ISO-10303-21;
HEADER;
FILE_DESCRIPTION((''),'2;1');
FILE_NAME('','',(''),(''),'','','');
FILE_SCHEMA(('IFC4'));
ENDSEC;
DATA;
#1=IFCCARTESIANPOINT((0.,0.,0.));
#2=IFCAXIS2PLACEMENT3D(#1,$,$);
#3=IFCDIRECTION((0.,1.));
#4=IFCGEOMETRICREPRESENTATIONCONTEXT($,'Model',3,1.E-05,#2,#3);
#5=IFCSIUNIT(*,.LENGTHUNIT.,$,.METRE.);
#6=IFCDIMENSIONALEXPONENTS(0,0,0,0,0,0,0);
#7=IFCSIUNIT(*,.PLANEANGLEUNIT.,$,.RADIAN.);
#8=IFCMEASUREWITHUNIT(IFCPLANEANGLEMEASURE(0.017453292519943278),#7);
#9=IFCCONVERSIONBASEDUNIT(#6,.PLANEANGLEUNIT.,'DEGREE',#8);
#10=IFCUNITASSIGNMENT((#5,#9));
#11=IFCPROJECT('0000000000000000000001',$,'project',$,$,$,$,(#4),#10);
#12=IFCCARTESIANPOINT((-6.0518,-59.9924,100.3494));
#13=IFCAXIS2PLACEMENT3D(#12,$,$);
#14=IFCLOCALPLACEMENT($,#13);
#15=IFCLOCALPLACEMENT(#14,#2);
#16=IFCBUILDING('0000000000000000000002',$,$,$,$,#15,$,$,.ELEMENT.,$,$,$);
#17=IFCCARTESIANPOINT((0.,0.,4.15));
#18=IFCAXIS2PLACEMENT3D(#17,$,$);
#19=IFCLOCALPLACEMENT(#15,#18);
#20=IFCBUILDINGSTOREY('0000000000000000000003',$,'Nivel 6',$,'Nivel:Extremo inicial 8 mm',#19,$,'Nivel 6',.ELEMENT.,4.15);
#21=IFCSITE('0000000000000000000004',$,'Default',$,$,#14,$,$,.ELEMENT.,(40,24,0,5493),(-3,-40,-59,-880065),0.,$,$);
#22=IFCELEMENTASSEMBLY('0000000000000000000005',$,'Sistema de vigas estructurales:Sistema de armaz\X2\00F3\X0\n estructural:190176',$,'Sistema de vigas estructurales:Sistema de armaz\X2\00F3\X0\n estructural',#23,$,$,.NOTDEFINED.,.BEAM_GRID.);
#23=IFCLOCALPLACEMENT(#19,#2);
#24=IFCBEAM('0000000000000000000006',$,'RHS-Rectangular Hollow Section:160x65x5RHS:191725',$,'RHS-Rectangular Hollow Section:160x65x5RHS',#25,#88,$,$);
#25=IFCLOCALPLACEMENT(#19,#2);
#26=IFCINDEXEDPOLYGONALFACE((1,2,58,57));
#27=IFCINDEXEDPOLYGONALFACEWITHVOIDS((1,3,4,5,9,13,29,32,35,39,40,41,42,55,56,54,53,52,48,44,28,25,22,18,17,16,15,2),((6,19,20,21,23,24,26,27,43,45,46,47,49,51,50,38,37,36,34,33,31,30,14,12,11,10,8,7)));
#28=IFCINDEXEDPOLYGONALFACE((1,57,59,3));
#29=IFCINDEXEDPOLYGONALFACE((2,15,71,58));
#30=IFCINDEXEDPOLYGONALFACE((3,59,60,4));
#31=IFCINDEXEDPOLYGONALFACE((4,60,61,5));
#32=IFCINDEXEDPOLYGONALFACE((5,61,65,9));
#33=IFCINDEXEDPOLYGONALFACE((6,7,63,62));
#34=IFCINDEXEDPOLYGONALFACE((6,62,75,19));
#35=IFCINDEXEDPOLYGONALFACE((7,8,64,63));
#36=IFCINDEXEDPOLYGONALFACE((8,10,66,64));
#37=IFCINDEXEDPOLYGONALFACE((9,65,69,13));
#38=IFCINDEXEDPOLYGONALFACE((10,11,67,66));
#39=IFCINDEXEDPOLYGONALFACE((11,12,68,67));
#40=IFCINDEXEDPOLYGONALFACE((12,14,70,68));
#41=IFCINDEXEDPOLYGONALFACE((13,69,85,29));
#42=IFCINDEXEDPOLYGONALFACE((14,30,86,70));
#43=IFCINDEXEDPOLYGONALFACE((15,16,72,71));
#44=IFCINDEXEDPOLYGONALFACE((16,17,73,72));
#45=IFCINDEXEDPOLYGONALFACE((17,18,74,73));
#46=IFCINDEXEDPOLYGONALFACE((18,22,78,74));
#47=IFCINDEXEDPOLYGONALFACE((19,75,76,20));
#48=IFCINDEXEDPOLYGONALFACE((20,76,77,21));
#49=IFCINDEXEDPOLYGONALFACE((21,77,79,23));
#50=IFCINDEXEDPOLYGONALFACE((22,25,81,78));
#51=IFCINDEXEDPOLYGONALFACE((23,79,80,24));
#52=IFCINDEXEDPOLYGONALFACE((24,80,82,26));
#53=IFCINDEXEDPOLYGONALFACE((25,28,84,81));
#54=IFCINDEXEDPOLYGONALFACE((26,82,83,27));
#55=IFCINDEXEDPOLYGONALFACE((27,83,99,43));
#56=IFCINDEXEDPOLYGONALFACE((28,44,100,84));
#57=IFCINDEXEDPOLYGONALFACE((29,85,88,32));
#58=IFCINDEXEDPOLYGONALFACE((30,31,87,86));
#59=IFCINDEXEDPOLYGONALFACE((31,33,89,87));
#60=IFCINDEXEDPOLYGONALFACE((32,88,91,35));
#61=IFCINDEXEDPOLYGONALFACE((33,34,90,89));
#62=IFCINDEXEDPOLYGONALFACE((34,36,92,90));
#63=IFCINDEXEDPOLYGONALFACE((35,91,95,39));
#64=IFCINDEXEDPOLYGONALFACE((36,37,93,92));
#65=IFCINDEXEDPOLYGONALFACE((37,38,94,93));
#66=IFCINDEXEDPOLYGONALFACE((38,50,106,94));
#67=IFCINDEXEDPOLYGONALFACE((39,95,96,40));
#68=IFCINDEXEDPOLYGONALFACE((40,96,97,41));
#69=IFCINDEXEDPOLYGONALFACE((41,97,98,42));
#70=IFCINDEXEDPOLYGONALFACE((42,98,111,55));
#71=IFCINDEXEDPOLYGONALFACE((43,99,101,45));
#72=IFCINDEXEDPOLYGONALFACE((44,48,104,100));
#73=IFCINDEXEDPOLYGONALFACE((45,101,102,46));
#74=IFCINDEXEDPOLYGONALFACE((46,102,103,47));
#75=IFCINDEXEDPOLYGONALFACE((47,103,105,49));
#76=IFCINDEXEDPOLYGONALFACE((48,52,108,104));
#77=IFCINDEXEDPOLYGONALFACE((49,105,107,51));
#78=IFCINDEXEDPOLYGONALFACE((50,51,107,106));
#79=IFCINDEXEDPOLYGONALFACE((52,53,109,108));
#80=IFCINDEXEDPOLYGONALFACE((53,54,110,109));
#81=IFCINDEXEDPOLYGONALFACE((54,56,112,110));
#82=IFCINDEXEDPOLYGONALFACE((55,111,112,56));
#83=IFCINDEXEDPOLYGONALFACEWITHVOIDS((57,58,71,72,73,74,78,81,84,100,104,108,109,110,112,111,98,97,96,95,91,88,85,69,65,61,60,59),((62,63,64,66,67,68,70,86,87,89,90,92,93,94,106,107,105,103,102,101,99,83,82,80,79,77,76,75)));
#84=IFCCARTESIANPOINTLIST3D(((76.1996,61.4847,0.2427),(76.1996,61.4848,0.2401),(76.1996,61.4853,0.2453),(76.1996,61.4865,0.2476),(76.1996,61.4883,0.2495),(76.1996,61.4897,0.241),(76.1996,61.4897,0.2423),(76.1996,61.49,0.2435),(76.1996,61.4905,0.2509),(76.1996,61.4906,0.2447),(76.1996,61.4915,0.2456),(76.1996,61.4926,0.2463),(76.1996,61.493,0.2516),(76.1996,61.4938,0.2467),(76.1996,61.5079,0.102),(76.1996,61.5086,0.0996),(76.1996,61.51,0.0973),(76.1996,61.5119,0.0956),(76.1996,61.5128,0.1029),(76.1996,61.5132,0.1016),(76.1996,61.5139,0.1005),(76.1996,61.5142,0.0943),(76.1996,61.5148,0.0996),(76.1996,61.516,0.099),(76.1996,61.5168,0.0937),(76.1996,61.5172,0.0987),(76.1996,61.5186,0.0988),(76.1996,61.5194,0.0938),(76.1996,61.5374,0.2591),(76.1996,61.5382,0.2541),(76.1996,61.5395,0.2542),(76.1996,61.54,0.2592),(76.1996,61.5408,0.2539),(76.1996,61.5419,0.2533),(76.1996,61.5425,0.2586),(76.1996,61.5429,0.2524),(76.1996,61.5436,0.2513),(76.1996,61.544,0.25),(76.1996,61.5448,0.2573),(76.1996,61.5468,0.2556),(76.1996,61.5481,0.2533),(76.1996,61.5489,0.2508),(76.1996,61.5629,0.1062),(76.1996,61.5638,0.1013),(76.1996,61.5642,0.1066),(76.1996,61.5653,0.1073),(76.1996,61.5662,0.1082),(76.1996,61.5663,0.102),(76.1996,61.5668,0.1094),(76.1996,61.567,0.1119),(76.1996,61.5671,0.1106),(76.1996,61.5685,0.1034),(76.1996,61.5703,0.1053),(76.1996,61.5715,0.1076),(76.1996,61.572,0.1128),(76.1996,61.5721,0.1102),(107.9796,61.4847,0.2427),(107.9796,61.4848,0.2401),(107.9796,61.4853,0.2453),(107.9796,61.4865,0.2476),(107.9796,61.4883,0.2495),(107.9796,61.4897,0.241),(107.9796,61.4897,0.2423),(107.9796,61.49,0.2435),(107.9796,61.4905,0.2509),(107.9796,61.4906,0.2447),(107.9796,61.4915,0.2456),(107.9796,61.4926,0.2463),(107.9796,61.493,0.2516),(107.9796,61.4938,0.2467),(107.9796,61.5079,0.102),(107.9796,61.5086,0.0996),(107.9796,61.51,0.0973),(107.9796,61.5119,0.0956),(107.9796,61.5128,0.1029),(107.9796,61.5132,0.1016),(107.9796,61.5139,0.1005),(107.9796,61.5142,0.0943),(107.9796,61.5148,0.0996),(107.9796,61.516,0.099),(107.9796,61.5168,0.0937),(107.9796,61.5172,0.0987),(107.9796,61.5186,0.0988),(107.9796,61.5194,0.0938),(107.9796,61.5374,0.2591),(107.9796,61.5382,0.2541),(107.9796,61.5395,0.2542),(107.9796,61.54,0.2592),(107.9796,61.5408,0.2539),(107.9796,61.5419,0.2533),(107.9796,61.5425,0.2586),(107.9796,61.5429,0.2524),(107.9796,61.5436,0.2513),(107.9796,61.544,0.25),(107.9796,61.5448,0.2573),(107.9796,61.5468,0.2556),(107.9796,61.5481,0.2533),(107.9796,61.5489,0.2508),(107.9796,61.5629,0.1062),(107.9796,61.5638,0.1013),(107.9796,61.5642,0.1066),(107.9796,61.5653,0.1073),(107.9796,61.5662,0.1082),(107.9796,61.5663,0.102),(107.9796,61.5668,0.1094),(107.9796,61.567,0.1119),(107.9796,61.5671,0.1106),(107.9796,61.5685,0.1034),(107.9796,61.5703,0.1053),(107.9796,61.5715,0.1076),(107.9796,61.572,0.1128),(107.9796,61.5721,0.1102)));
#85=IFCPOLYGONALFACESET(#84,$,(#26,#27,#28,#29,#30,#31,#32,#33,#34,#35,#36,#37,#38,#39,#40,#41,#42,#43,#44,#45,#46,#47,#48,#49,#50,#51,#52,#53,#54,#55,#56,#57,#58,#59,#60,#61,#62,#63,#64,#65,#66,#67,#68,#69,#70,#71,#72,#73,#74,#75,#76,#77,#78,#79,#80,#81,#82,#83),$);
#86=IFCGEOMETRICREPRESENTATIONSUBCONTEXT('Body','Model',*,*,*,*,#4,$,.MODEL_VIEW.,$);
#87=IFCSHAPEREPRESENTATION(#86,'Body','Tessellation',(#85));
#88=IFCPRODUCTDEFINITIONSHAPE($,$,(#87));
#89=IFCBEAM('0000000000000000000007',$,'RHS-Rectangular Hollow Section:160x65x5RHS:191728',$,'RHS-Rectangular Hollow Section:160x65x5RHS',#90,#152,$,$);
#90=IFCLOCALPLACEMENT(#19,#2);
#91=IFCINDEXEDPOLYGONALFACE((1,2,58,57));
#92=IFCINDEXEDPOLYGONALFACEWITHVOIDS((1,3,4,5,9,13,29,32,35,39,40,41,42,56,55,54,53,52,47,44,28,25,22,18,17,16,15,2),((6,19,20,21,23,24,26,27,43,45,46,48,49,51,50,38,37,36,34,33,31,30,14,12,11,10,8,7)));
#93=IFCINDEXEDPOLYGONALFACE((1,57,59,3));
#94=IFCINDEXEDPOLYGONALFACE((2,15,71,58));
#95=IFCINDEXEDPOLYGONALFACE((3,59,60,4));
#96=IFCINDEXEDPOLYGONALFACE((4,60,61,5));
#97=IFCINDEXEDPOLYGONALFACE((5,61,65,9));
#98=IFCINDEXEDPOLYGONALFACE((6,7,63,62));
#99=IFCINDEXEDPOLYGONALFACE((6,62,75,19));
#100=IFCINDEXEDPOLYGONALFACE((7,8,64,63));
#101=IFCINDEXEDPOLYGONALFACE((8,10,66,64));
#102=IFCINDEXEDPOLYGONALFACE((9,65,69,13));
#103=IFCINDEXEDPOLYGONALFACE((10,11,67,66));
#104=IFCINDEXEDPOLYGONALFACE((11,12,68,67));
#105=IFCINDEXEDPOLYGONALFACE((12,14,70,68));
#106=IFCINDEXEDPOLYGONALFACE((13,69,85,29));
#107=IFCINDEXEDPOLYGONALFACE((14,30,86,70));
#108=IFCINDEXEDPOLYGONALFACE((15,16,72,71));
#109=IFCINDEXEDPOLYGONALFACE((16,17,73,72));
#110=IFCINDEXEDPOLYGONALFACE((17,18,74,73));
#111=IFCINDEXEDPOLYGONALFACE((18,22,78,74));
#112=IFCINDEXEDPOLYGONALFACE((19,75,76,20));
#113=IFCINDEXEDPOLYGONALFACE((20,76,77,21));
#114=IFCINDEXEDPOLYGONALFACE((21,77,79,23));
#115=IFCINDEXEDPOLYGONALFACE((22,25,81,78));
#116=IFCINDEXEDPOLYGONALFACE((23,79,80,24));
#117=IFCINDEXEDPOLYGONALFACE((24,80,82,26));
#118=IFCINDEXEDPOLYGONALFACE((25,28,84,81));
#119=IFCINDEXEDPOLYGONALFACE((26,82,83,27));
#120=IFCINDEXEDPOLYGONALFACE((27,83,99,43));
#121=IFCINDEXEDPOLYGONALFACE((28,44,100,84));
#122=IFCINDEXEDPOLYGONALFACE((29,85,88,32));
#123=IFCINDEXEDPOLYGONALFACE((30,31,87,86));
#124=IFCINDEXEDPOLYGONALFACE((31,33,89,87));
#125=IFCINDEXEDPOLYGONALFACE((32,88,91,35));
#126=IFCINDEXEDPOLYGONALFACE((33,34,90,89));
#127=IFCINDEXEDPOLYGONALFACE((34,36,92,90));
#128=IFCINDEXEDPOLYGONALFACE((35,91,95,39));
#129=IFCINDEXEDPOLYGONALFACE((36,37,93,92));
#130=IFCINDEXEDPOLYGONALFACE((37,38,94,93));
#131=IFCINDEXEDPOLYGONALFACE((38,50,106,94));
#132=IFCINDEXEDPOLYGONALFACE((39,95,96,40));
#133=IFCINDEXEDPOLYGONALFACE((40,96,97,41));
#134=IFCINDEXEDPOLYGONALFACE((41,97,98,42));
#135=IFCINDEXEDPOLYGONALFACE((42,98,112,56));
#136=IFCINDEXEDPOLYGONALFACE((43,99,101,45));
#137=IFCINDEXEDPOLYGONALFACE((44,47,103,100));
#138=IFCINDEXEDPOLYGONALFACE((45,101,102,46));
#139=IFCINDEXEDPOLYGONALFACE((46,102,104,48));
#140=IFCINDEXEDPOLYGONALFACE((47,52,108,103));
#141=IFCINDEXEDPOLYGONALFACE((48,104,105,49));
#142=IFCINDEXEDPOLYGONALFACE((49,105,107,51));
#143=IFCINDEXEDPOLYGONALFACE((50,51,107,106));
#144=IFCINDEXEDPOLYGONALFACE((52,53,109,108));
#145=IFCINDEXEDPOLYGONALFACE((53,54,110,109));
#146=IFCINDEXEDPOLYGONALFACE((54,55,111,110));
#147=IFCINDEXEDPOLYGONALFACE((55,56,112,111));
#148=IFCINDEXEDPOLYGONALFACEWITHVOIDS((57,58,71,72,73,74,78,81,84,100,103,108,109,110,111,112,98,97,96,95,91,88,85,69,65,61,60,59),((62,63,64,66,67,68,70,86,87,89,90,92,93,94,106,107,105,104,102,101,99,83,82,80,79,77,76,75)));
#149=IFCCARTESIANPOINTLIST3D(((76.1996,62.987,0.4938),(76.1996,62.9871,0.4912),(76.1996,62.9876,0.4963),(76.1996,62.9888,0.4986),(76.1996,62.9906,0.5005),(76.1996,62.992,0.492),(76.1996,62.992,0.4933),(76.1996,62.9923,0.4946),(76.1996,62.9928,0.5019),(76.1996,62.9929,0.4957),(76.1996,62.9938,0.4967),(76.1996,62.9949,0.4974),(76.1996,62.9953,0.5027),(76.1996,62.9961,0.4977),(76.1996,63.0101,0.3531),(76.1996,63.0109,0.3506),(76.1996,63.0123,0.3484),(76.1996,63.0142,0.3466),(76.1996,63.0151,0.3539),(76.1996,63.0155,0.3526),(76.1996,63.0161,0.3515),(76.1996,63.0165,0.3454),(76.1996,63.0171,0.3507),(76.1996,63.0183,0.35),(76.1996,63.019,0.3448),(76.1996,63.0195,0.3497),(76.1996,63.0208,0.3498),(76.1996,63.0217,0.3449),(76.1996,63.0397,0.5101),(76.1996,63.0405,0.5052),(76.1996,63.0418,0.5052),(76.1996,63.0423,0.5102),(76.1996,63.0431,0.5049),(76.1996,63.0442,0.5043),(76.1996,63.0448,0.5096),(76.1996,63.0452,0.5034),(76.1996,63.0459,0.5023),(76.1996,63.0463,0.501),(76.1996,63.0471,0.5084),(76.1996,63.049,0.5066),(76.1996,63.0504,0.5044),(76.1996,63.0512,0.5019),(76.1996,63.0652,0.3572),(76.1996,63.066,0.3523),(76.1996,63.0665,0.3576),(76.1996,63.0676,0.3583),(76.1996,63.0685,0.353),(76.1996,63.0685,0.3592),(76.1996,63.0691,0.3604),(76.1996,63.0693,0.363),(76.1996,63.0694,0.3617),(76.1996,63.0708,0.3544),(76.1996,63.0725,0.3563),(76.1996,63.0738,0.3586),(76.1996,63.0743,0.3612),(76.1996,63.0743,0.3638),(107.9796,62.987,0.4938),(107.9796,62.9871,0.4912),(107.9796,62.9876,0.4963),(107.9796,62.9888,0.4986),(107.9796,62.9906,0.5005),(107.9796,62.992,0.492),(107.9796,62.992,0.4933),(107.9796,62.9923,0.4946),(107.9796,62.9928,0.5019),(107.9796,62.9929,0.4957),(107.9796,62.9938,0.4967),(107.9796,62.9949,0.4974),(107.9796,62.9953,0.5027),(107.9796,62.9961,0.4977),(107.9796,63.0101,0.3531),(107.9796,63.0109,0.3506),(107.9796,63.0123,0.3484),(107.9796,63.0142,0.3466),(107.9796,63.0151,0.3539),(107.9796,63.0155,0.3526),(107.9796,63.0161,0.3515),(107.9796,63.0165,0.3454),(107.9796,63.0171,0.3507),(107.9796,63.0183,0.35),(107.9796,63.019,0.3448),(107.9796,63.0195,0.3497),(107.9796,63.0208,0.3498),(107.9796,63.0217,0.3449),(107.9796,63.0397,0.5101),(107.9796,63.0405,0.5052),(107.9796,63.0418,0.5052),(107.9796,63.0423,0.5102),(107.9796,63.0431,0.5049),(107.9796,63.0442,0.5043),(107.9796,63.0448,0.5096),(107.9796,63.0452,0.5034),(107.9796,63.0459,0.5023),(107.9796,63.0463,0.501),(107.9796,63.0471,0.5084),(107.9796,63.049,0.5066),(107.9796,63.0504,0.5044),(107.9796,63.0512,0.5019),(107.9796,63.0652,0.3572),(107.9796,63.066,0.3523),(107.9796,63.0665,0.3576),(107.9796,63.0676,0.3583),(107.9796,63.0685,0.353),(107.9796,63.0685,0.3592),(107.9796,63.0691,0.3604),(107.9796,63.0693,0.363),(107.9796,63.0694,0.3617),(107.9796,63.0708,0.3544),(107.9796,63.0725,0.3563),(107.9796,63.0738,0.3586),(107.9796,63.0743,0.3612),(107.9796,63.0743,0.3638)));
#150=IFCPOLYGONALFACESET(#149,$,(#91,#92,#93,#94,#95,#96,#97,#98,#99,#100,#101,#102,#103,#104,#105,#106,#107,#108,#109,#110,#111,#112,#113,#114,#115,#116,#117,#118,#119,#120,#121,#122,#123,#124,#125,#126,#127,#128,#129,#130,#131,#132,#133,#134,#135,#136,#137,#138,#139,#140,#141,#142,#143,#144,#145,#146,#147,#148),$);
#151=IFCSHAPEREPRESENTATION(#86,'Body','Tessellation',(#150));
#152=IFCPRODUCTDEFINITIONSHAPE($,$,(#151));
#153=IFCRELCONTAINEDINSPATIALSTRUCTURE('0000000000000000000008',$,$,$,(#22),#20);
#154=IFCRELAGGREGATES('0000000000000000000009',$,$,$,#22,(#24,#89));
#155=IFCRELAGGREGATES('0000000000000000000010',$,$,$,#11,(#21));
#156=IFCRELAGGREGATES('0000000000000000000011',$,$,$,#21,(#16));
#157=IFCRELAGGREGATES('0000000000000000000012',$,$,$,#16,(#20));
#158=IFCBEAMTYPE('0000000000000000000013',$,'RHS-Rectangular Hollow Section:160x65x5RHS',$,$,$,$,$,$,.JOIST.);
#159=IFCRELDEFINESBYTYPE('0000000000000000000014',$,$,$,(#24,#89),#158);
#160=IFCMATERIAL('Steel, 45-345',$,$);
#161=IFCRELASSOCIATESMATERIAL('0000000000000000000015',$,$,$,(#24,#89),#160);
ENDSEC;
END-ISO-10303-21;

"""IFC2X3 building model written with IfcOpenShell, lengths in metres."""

from ifc_helpers import new_model, entity, si_unit, converted_unit, direction, frame, frame_2d, origin, place, context, subcontext, project, spatial, polyline, circle_curve, parameter, trimmed, segment, composite_curve, outline, extrude, material, type_object, element, aggregate, save


model = new_model("IFC2X3")

# Units and contexts
model_context = context("Model", 3, precision=1e-05, world=origin(), true_north=direction((0.0, 1.0)))
body_context = subcontext(model_context, "Body", "Model", "MODEL_VIEW")
ifc_project = project(units=[si_unit("LENGTHUNIT", "METRE"), converted_unit("PLANEANGLEUNIT", "DEGREE", entity("IfcPlaneAngleMeasure", 0.017453292519943278), si_unit("PLANEANGLEUNIT", "RADIAN"), dimensions=[0, 0, 0, 0, 0, 0, 0])], contexts=[model_context])

# Site, building, storey
site_placement = place(None, frame((-6.0518, -59.9924, 100.3494)))
site = spatial("IfcSite", under=ifc_project, at=site_placement, Name="Default", CompositionType="ELEMENT", RefLatitude=(40, 24, 0, 5493), RefLongitude=(-3, -40, -59, -880065), RefElevation=0.0)
building_placement = place(site_placement, origin())
building = spatial("IfcBuilding", under=site, at=building_placement, CompositionType="ELEMENT")
storey_placement = place(building_placement, frame((0.0, 0.0, 4.15)))
storey = spatial("IfcBuildingStorey", under=building, at=storey_placement, Name="Nivel 6", ObjectType="Nivel:Extremo inicial 8 mm", LongName="Nivel 6", CompositionType="ELEMENT", Elevation=4.15)

# Shared definitions
ifc_material_1 = material(Name="Steel, 45-345")

# Element assembly, beams
assembly_placement = place(storey_placement, origin())
assembly = element("IfcElementAssembly", 1, at=assembly_placement, inside=storey, Name="Sistema de vigas estructurales:Sistema de armazón estructural:190176", ObjectType="Sistema de vigas estructurales:Sistema de armazón estructural", AssemblyPlace="NOTDEFINED", PredefinedType="BEAM_GRID")
beam_type_1 = type_object("IfcBeamType", Name="RHS-Rectangular Hollow Section:160x65x5RHS", PredefinedType="JOIST")
beam_1_placement = place(assembly_placement, frame((76.1996, 61.5679, -0.0603)))
beam_1 = element("IfcBeam", 2, at=beam_1_placement, type_object=beam_type_1, material=ifc_material_1, Name="RHS-Rectangular Hollow Section:160x65x5RHS:191725", ObjectType="RHS-Rectangular Hollow Section:160x65x5RHS", context=body_context, shape_type="SweptSolid", body=[
    extrude(outline(composite_curve([segment(trimmed(circle_curve(frame_2d((-0.0225, -0.07), x_axis=(1.0, 0.0)), 0.01), [parameter(180.0)], [parameter(270.0)], True, "PARAMETER"), True, "CONTINUOUS"), segment(polyline([(-0.0225, -0.08), (0.0225, -0.08)]), True, "CONTINUOUS"), segment(trimmed(circle_curve(frame_2d((0.0225, -0.07), x_axis=(1.0, 0.0)), 0.01), [parameter(270.0)], [parameter(0.0)], True, "PARAMETER"), True, "CONTINUOUS"), segment(polyline([(0.0325, -0.07), (0.0325, 0.07)]), True, "CONTINUOUS"), segment(trimmed(circle_curve(frame_2d((0.0225, 0.07), x_axis=(1.0, 0.0)), 0.01), [parameter(360.0)], [parameter(90.0)], True, "PARAMETER"), True, "CONTINUOUS"), segment(polyline([(0.0225, 0.08), (-0.0225, 0.08)]), True, "CONTINUOUS"), segment(trimmed(circle_curve(frame_2d((-0.0225, 0.07), x_axis=(1.0, 0.0)), 0.01), [parameter(90.0)], [parameter(180.0)], True, "PARAMETER"), True, "CONTINUOUS"), segment(polyline([(-0.0325, 0.07), (-0.0325, -0.07)]), True, "CONTINUOUS")], self_intersect=False), holes=[composite_curve([segment(polyline([(0.0225, -0.075), (-0.0225, -0.075)]), True, "CONTINUOUS"), segment(trimmed(circle_curve(frame_2d((-0.0225, -0.07), x_axis=(1.0, 0.0)), 0.005), [parameter(180.0)], [parameter(270.0)], True, "PARAMETER"), False, "CONTINUOUS"), segment(polyline([(-0.0275, -0.07), (-0.0275, 0.07)]), True, "CONTINUOUS"), segment(trimmed(circle_curve(frame_2d((-0.0225, 0.07), x_axis=(1.0, 0.0)), 0.005), [parameter(90.0)], [parameter(180.0)], True, "PARAMETER"), False, "CONTINUOUS"), segment(polyline([(-0.0225, 0.075), (0.0225, 0.075)]), True, "CONTINUOUS"), segment(trimmed(circle_curve(frame_2d((0.0225, 0.07), x_axis=(1.0, 0.0)), 0.005), [parameter(0.0)], [parameter(90.0)], True, "PARAMETER"), False, "CONTINUOUS"), segment(polyline([(0.0275, 0.07), (0.0275, -0.07)]), True, "CONTINUOUS"), segment(trimmed(circle_curve(frame_2d((0.0225, -0.07), x_axis=(1.0, 0.0)), 0.005), [parameter(270.0)], [parameter(0.0)], True, "PARAMETER"), False, "CONTINUOUS")], self_intersect=False)]), frame((0.0, -0.0396, 0.2367), z_axis=(1.0, 0.0, 0.0), x_axis=(0.0, -0.986325, -0.16481)), (0.0, 0.0, 1.0), 31.78),
])
beam_2_placement = place(assembly_placement, frame((76.1996, 63.0702, 0.1908)))
beam_2 = element("IfcBeam", 3, at=beam_2_placement, type_object=beam_type_1, material=ifc_material_1, Name="RHS-Rectangular Hollow Section:160x65x5RHS:191728", ObjectType="RHS-Rectangular Hollow Section:160x65x5RHS", context=body_context, shape_type="SweptSolid", body=[
    extrude(outline(composite_curve([segment(trimmed(circle_curve(frame_2d((-0.0225, -0.07), x_axis=(1.0, 0.0)), 0.01), [parameter(180.0)], [parameter(270.0)], True, "PARAMETER"), True, "CONTINUOUS"), segment(polyline([(-0.0225, -0.08), (0.0225, -0.08)]), True, "CONTINUOUS"), segment(trimmed(circle_curve(frame_2d((0.0225, -0.07), x_axis=(1.0, 0.0)), 0.01), [parameter(270.0)], [parameter(0.0)], True, "PARAMETER"), True, "CONTINUOUS"), segment(polyline([(0.0325, -0.07), (0.0325, 0.07)]), True, "CONTINUOUS"), segment(trimmed(circle_curve(frame_2d((0.0225, 0.07), x_axis=(1.0, 0.0)), 0.01), [parameter(360.0)], [parameter(90.0)], True, "PARAMETER"), True, "CONTINUOUS"), segment(polyline([(0.0225, 0.08), (-0.0225, 0.08)]), True, "CONTINUOUS"), segment(trimmed(circle_curve(frame_2d((-0.0225, 0.07), x_axis=(1.0, 0.0)), 0.01), [parameter(90.0)], [parameter(180.0)], True, "PARAMETER"), True, "CONTINUOUS"), segment(polyline([(-0.0325, 0.07), (-0.0325, -0.07)]), True, "CONTINUOUS")], self_intersect=False), holes=[composite_curve([segment(polyline([(0.0225, -0.075), (-0.0225, -0.075)]), True, "CONTINUOUS"), segment(trimmed(circle_curve(frame_2d((-0.0225, -0.07), x_axis=(1.0, 0.0)), 0.005), [parameter(180.0)], [parameter(270.0)], True, "PARAMETER"), False, "CONTINUOUS"), segment(polyline([(-0.0275, -0.07), (-0.0275, 0.07)]), True, "CONTINUOUS"), segment(trimmed(circle_curve(frame_2d((-0.0225, 0.07), x_axis=(1.0, 0.0)), 0.005), [parameter(90.0)], [parameter(180.0)], True, "PARAMETER"), False, "CONTINUOUS"), segment(polyline([(-0.0225, 0.075), (0.0225, 0.075)]), True, "CONTINUOUS"), segment(trimmed(circle_curve(frame_2d((0.0225, 0.07), x_axis=(1.0, 0.0)), 0.005), [parameter(0.0)], [parameter(90.0)], True, "PARAMETER"), False, "CONTINUOUS"), segment(polyline([(0.0275, 0.07), (0.0275, -0.07)]), True, "CONTINUOUS"), segment(trimmed(circle_curve(frame_2d((0.0225, -0.07), x_axis=(1.0, 0.0)), 0.005), [parameter(270.0)], [parameter(0.0)], True, "PARAMETER"), False, "CONTINUOUS")], self_intersect=False)]), frame((0.0, -0.0396, 0.2367), z_axis=(1.0, 0.0, 0.0), x_axis=(0.0, -0.986325, -0.16481)), (0.0, 0.0, 1.0), 31.78),
])
aggregate(assembly, [beam_1, beam_2])

save(model, "model.ifc")
